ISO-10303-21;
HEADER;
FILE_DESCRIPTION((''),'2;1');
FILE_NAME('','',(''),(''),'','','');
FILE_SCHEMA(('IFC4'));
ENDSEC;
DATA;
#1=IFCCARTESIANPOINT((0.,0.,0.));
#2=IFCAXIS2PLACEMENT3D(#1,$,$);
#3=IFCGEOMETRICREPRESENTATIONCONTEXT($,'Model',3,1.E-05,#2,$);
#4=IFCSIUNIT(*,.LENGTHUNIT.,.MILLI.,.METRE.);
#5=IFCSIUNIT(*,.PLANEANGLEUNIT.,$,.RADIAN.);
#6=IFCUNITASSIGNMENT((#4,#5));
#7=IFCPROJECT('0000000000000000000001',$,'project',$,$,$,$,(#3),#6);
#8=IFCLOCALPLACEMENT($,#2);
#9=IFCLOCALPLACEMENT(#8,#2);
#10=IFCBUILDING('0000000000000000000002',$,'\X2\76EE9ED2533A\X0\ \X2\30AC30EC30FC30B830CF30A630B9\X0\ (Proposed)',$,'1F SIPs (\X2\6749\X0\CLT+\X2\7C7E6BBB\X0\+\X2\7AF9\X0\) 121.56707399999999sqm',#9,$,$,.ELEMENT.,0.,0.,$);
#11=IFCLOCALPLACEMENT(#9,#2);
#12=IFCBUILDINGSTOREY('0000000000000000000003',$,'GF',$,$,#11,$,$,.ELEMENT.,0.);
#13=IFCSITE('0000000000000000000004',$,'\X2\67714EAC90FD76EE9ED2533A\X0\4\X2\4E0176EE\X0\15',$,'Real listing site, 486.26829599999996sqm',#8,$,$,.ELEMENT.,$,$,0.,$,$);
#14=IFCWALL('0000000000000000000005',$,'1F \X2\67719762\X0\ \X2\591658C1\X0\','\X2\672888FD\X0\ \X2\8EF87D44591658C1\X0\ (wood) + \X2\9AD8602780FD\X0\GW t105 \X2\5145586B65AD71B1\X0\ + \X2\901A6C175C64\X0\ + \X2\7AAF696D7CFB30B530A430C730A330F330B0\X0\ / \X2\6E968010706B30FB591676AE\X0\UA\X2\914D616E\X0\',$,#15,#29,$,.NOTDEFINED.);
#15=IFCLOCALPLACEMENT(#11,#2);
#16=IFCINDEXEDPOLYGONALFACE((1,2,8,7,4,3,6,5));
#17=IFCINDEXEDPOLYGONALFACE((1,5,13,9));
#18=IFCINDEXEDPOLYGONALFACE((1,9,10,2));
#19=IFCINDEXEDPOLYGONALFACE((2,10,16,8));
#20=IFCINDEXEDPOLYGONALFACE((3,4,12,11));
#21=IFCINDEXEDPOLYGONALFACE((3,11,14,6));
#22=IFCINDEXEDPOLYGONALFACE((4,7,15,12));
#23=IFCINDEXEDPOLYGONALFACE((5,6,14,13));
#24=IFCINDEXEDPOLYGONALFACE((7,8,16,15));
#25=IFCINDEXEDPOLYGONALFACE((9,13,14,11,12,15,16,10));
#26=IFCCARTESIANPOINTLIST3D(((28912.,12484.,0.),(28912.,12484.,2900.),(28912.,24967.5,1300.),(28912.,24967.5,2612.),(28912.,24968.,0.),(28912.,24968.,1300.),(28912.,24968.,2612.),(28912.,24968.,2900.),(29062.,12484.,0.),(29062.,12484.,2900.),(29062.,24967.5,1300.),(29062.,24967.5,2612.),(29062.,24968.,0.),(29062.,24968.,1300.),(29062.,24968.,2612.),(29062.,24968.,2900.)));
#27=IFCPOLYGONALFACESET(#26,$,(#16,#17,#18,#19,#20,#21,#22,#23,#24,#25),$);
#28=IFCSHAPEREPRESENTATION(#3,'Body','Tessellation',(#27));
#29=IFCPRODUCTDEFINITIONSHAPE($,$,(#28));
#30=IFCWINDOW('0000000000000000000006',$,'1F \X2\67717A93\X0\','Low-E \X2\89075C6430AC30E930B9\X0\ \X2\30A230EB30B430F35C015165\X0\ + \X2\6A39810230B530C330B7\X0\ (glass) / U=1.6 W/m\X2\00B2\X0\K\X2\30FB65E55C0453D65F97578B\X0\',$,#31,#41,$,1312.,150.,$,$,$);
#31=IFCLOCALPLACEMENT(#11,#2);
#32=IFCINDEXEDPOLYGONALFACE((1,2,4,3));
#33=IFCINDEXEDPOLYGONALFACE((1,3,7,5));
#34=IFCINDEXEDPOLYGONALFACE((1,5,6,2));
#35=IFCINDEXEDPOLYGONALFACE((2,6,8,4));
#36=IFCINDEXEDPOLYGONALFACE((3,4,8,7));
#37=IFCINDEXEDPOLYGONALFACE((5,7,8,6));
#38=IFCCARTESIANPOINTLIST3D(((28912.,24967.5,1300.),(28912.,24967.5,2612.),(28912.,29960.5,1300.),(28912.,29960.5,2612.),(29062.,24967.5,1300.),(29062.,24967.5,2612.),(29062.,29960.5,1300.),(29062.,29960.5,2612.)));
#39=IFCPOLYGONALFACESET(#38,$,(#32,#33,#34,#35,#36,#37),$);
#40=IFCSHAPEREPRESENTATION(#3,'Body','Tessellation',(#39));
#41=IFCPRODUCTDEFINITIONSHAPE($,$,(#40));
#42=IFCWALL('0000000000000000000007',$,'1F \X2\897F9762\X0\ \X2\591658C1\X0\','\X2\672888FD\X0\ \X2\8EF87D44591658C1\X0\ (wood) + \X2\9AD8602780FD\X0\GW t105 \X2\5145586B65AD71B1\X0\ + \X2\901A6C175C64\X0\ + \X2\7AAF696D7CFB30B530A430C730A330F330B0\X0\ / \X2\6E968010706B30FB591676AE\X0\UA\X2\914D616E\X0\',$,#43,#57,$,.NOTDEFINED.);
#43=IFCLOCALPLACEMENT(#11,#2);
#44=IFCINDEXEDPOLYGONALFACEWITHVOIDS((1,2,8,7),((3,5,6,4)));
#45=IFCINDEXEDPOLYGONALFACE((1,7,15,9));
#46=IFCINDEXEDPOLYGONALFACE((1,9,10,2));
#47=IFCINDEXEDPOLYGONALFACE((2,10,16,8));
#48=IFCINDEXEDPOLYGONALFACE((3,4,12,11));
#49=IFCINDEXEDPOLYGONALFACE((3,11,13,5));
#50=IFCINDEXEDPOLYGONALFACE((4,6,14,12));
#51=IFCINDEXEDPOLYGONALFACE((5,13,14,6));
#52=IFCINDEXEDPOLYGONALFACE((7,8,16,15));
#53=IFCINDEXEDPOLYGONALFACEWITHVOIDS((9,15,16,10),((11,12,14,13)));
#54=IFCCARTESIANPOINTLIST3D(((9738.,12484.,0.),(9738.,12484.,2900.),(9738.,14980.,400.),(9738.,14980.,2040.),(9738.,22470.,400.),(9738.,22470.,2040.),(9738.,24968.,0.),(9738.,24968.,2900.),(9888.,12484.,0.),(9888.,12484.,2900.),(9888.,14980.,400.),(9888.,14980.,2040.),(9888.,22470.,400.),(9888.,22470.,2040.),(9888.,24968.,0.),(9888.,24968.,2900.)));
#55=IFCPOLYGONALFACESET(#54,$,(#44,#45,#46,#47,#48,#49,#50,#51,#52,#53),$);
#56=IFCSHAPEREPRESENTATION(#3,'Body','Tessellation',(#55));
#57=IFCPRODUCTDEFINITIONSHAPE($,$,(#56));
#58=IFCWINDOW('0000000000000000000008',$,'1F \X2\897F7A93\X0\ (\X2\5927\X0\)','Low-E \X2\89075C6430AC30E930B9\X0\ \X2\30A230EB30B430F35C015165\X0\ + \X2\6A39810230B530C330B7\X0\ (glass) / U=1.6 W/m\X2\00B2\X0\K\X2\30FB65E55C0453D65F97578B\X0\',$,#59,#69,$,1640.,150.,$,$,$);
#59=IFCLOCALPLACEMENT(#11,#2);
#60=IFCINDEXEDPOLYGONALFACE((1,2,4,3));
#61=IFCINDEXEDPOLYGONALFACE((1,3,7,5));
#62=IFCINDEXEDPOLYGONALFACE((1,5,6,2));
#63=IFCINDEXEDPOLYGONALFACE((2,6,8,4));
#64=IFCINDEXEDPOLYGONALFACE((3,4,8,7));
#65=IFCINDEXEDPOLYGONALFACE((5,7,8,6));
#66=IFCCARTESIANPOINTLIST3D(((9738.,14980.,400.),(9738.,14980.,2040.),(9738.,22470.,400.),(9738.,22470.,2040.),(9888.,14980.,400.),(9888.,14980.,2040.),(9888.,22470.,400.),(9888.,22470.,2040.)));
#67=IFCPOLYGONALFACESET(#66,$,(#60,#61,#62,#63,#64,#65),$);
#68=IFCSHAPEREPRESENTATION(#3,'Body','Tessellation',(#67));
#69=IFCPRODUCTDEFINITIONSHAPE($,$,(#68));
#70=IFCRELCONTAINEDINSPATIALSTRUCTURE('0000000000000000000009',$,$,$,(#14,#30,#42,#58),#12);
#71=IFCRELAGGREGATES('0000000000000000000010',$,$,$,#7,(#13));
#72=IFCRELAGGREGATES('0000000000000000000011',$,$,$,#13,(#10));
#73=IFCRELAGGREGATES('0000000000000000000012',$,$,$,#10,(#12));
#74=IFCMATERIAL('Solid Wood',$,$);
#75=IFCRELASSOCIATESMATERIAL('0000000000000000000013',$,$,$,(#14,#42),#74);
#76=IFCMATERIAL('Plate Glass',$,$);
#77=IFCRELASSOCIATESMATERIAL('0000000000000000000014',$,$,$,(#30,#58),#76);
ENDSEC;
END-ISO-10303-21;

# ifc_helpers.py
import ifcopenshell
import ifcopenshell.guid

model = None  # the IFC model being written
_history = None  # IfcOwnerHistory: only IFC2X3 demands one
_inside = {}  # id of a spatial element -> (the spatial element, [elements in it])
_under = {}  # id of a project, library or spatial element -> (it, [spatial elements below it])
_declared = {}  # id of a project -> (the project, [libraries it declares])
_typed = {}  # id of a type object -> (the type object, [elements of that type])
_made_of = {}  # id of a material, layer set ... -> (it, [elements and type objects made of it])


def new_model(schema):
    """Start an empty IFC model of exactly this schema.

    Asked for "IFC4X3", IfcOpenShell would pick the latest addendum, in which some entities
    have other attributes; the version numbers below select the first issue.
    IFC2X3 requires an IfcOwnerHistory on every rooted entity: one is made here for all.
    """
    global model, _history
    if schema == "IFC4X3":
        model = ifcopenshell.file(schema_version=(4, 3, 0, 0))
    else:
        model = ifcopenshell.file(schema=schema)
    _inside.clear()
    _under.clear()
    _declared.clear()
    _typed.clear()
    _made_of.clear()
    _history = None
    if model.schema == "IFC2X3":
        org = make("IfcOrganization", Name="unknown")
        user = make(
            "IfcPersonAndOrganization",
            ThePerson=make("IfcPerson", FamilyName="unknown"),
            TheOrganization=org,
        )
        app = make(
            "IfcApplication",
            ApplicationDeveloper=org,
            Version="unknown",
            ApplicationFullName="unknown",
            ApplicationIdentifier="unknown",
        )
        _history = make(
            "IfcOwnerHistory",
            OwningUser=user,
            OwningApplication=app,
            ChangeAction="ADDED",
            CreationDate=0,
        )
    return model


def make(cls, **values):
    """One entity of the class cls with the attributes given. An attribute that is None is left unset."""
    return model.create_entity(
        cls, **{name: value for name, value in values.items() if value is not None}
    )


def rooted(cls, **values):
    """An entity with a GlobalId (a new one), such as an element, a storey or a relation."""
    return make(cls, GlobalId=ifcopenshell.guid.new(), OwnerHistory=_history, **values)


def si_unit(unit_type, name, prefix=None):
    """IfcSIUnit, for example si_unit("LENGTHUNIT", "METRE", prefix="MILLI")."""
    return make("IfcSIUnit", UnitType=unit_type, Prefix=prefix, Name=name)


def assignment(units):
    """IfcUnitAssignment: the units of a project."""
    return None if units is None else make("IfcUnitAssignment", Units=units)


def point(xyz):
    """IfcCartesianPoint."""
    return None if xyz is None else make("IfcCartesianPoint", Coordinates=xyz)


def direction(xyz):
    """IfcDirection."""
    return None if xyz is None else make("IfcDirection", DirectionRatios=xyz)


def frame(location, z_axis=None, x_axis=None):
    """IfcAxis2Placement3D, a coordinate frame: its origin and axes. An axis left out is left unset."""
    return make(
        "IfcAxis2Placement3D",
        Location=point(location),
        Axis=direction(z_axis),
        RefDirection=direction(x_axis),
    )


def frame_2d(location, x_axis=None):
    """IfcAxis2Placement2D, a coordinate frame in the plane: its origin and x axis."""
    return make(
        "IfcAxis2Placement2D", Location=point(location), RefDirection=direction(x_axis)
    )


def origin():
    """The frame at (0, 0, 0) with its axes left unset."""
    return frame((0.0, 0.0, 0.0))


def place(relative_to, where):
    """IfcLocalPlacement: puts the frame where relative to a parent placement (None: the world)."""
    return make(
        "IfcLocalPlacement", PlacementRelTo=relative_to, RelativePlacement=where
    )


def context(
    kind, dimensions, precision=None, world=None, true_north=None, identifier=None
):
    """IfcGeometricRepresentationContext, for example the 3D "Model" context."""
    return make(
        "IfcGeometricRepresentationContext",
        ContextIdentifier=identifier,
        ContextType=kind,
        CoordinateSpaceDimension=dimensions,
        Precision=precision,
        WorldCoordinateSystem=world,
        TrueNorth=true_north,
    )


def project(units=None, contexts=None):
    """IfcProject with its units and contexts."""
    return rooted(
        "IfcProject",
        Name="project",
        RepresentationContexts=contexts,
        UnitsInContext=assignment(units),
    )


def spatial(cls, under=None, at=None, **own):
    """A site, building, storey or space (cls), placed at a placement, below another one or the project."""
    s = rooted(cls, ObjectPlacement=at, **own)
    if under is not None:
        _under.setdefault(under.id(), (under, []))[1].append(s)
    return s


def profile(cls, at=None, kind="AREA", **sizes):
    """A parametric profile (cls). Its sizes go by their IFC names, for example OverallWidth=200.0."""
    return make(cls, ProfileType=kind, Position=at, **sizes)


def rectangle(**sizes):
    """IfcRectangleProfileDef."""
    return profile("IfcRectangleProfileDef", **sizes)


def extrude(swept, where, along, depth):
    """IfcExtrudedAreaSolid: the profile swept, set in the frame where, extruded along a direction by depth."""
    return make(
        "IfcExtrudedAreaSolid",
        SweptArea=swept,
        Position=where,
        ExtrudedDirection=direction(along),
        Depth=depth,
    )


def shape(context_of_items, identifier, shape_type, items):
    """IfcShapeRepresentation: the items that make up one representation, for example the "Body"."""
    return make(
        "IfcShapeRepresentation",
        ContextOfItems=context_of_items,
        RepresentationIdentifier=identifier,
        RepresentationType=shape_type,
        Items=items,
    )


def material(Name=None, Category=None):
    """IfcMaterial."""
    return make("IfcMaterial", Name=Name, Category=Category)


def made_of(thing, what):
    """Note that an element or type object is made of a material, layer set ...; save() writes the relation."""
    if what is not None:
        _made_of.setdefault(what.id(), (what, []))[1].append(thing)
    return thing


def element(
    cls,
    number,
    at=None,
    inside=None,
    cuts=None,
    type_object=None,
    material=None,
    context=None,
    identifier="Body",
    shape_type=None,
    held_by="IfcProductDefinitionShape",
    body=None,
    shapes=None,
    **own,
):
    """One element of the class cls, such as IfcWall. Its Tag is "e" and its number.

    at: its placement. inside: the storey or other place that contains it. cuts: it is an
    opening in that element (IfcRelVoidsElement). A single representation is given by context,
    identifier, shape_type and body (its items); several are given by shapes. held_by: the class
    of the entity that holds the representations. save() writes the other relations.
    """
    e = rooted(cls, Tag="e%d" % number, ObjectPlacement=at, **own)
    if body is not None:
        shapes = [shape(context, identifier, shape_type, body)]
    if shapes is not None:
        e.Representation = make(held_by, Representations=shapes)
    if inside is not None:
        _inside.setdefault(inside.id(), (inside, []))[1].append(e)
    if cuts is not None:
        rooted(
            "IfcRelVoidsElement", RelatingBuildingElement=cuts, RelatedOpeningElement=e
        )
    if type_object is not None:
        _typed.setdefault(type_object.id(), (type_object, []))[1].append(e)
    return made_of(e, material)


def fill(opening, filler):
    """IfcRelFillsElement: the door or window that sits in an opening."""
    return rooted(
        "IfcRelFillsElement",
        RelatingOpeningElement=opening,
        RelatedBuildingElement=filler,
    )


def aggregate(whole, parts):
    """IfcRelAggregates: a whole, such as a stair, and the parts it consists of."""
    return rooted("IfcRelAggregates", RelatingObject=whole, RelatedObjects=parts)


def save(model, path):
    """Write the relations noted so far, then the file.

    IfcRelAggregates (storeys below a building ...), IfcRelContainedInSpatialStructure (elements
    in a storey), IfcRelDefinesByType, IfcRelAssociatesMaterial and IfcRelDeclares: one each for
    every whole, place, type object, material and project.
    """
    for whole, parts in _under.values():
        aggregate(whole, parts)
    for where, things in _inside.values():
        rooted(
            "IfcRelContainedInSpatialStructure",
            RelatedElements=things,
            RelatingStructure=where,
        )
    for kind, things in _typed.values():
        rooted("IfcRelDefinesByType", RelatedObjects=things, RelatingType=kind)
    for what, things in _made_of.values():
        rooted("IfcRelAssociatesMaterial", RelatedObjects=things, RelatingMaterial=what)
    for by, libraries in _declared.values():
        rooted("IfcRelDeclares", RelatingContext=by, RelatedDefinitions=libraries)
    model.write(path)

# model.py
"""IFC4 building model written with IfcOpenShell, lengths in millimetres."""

from ifc_helpers import new_model, si_unit, frame, frame_2d, origin, place, context, project, spatial, rectangle, extrude, material, element, fill, save


model = new_model("IFC4")

# Units and contexts
model_context = context("Model", 3, precision=1e-05, world=origin())
ifc_project = project(units=[si_unit("LENGTHUNIT", "METRE", prefix="MILLI"), si_unit("PLANEANGLEUNIT", "RADIAN")], contexts=[model_context])

# Site, building, storey
site_placement = place(None, origin())
site = spatial("IfcSite", under=ifc_project, at=site_placement, Name="東京都目黒区4丁目15", ObjectType="Real listing site, 486.26829599999996sqm", CompositionType="ELEMENT", RefElevation=0.0)
building_placement = place(site_placement, origin())
building = spatial("IfcBuilding", under=site, at=building_placement, Name="目黒区 ガレージハウス (Proposed)", ObjectType="1F SIPs (杉CLT+籾殻+竹) 121.56707399999999sqm", CompositionType="ELEMENT", ElevationOfRefHeight=0.0, ElevationOfTerrain=0.0)
storey_placement = place(building_placement, origin())
storey = spatial("IfcBuildingStorey", under=building, at=storey_placement, Name="GF", CompositionType="ELEMENT", Elevation=0.0)

# Shared definitions
ifc_material_1 = material(Name="Solid Wood")

# Shared definitions
ifc_material_2 = material(Name="Plate Glass")

# Walls, openings, windows
wall_1_placement = place(storey_placement, frame((14456.0, 6242.0, 0.0)))
wall_1 = element("IfcWall", 1, at=wall_1_placement, inside=storey, material=ifc_material_1, Name="1F 東面 外壁", Description="木製 軸組外壁 (wood) + 高性能GW t105 充填断熱 + 通気層 + 窯業系サイディング / 準耐火・外皮UA配慮", PredefinedType="NOTDEFINED", context=model_context, shape_type="SweptSolid", body=[
    extrude(rectangle(XDim=150.0, YDim=12484.0, at=frame_2d((75.0, 6242.0))), frame((14456.0, 6242.0, 0.0)), (0.0, 0.0, 1.0), 2900.0),
])
opening_1_placement = place(storey_placement, frame((14456.0, 12484.0, 650.0)))
opening_1 = element("IfcOpeningElement", 2, at=opening_1_placement, cuts=wall_1, PredefinedType="NOTDEFINED", context=model_context, shape_type="SweptSolid", body=[
    extrude(rectangle(XDim=150.0, YDim=4993.0, at=frame_2d((75.0, 2496.0))), frame((14456.0, 12484.0, 650.0)), (0.0, 0.0, 1.0), 1312.0),
])
window_1_placement = place(storey_placement, frame((14456.0, 12484.0, 650.0)))
window_1 = element("IfcWindow", 3, at=window_1_placement, inside=storey, material=ifc_material_2, Name="1F 東窓", Description="Low-E 複層ガラス アルゴン封入 + 樹脂サッシ (glass) / U=1.6 W/m²K・日射取得型", OverallHeight=1312.0, OverallWidth=150.0, context=model_context, shape_type="SweptSolid", body=[
    extrude(rectangle(XDim=150.0, YDim=4993.0, at=frame_2d((75.0, 2496.0))), frame((14456.0, 12484.0, 650.0)), (0.0, 0.0, 1.0), 1312.0),
])
fill(opening_1, window_1)
wall_2_placement = place(storey_placement, frame((4869.0, 6242.0, 0.0)))
wall_2 = element("IfcWall", 4, at=wall_2_placement, inside=storey, material=ifc_material_1, Name="1F 西面 外壁", Description="木製 軸組外壁 (wood) + 高性能GW t105 充填断熱 + 通気層 + 窯業系サイディング / 準耐火・外皮UA配慮", PredefinedType="NOTDEFINED", context=model_context, shape_type="SweptSolid", body=[
    extrude(rectangle(XDim=150.0, YDim=12484.0, at=frame_2d((75.0, 6242.0))), frame((4869.0, 6242.0, 0.0)), (0.0, 0.0, 1.0), 2900.0),
])
opening_2_placement = place(storey_placement, frame((4869.0, 7490.0, 200.0)))
opening_2 = element("IfcOpeningElement", 5, at=opening_2_placement, cuts=wall_2, PredefinedType="NOTDEFINED", context=model_context, shape_type="SweptSolid", body=[
    extrude(rectangle(XDim=150.0, YDim=7490.0, at=frame_2d((75.0, 3745.0))), frame((4869.0, 7490.0, 200.0)), (0.0, 0.0, 1.0), 1640.0),
])
window_2_placement = place(storey_placement, frame((4869.0, 7490.0, 200.0)))
window_2 = element("IfcWindow", 6, at=window_2_placement, inside=storey, material=ifc_material_2, Name="1F 西窓 (大)", Description="Low-E 複層ガラス アルゴン封入 + 樹脂サッシ (glass) / U=1.6 W/m²K・日射取得型", OverallHeight=1640.0, OverallWidth=150.0, context=model_context, shape_type="SweptSolid", body=[
    extrude(rectangle(XDim=150.0, YDim=7490.0, at=frame_2d((75.0, 3745.0))), frame((4869.0, 7490.0, 200.0)), (0.0, 0.0, 1.0), 1640.0),
])
fill(opening_2, window_2)

save(model, "model.ifc")
